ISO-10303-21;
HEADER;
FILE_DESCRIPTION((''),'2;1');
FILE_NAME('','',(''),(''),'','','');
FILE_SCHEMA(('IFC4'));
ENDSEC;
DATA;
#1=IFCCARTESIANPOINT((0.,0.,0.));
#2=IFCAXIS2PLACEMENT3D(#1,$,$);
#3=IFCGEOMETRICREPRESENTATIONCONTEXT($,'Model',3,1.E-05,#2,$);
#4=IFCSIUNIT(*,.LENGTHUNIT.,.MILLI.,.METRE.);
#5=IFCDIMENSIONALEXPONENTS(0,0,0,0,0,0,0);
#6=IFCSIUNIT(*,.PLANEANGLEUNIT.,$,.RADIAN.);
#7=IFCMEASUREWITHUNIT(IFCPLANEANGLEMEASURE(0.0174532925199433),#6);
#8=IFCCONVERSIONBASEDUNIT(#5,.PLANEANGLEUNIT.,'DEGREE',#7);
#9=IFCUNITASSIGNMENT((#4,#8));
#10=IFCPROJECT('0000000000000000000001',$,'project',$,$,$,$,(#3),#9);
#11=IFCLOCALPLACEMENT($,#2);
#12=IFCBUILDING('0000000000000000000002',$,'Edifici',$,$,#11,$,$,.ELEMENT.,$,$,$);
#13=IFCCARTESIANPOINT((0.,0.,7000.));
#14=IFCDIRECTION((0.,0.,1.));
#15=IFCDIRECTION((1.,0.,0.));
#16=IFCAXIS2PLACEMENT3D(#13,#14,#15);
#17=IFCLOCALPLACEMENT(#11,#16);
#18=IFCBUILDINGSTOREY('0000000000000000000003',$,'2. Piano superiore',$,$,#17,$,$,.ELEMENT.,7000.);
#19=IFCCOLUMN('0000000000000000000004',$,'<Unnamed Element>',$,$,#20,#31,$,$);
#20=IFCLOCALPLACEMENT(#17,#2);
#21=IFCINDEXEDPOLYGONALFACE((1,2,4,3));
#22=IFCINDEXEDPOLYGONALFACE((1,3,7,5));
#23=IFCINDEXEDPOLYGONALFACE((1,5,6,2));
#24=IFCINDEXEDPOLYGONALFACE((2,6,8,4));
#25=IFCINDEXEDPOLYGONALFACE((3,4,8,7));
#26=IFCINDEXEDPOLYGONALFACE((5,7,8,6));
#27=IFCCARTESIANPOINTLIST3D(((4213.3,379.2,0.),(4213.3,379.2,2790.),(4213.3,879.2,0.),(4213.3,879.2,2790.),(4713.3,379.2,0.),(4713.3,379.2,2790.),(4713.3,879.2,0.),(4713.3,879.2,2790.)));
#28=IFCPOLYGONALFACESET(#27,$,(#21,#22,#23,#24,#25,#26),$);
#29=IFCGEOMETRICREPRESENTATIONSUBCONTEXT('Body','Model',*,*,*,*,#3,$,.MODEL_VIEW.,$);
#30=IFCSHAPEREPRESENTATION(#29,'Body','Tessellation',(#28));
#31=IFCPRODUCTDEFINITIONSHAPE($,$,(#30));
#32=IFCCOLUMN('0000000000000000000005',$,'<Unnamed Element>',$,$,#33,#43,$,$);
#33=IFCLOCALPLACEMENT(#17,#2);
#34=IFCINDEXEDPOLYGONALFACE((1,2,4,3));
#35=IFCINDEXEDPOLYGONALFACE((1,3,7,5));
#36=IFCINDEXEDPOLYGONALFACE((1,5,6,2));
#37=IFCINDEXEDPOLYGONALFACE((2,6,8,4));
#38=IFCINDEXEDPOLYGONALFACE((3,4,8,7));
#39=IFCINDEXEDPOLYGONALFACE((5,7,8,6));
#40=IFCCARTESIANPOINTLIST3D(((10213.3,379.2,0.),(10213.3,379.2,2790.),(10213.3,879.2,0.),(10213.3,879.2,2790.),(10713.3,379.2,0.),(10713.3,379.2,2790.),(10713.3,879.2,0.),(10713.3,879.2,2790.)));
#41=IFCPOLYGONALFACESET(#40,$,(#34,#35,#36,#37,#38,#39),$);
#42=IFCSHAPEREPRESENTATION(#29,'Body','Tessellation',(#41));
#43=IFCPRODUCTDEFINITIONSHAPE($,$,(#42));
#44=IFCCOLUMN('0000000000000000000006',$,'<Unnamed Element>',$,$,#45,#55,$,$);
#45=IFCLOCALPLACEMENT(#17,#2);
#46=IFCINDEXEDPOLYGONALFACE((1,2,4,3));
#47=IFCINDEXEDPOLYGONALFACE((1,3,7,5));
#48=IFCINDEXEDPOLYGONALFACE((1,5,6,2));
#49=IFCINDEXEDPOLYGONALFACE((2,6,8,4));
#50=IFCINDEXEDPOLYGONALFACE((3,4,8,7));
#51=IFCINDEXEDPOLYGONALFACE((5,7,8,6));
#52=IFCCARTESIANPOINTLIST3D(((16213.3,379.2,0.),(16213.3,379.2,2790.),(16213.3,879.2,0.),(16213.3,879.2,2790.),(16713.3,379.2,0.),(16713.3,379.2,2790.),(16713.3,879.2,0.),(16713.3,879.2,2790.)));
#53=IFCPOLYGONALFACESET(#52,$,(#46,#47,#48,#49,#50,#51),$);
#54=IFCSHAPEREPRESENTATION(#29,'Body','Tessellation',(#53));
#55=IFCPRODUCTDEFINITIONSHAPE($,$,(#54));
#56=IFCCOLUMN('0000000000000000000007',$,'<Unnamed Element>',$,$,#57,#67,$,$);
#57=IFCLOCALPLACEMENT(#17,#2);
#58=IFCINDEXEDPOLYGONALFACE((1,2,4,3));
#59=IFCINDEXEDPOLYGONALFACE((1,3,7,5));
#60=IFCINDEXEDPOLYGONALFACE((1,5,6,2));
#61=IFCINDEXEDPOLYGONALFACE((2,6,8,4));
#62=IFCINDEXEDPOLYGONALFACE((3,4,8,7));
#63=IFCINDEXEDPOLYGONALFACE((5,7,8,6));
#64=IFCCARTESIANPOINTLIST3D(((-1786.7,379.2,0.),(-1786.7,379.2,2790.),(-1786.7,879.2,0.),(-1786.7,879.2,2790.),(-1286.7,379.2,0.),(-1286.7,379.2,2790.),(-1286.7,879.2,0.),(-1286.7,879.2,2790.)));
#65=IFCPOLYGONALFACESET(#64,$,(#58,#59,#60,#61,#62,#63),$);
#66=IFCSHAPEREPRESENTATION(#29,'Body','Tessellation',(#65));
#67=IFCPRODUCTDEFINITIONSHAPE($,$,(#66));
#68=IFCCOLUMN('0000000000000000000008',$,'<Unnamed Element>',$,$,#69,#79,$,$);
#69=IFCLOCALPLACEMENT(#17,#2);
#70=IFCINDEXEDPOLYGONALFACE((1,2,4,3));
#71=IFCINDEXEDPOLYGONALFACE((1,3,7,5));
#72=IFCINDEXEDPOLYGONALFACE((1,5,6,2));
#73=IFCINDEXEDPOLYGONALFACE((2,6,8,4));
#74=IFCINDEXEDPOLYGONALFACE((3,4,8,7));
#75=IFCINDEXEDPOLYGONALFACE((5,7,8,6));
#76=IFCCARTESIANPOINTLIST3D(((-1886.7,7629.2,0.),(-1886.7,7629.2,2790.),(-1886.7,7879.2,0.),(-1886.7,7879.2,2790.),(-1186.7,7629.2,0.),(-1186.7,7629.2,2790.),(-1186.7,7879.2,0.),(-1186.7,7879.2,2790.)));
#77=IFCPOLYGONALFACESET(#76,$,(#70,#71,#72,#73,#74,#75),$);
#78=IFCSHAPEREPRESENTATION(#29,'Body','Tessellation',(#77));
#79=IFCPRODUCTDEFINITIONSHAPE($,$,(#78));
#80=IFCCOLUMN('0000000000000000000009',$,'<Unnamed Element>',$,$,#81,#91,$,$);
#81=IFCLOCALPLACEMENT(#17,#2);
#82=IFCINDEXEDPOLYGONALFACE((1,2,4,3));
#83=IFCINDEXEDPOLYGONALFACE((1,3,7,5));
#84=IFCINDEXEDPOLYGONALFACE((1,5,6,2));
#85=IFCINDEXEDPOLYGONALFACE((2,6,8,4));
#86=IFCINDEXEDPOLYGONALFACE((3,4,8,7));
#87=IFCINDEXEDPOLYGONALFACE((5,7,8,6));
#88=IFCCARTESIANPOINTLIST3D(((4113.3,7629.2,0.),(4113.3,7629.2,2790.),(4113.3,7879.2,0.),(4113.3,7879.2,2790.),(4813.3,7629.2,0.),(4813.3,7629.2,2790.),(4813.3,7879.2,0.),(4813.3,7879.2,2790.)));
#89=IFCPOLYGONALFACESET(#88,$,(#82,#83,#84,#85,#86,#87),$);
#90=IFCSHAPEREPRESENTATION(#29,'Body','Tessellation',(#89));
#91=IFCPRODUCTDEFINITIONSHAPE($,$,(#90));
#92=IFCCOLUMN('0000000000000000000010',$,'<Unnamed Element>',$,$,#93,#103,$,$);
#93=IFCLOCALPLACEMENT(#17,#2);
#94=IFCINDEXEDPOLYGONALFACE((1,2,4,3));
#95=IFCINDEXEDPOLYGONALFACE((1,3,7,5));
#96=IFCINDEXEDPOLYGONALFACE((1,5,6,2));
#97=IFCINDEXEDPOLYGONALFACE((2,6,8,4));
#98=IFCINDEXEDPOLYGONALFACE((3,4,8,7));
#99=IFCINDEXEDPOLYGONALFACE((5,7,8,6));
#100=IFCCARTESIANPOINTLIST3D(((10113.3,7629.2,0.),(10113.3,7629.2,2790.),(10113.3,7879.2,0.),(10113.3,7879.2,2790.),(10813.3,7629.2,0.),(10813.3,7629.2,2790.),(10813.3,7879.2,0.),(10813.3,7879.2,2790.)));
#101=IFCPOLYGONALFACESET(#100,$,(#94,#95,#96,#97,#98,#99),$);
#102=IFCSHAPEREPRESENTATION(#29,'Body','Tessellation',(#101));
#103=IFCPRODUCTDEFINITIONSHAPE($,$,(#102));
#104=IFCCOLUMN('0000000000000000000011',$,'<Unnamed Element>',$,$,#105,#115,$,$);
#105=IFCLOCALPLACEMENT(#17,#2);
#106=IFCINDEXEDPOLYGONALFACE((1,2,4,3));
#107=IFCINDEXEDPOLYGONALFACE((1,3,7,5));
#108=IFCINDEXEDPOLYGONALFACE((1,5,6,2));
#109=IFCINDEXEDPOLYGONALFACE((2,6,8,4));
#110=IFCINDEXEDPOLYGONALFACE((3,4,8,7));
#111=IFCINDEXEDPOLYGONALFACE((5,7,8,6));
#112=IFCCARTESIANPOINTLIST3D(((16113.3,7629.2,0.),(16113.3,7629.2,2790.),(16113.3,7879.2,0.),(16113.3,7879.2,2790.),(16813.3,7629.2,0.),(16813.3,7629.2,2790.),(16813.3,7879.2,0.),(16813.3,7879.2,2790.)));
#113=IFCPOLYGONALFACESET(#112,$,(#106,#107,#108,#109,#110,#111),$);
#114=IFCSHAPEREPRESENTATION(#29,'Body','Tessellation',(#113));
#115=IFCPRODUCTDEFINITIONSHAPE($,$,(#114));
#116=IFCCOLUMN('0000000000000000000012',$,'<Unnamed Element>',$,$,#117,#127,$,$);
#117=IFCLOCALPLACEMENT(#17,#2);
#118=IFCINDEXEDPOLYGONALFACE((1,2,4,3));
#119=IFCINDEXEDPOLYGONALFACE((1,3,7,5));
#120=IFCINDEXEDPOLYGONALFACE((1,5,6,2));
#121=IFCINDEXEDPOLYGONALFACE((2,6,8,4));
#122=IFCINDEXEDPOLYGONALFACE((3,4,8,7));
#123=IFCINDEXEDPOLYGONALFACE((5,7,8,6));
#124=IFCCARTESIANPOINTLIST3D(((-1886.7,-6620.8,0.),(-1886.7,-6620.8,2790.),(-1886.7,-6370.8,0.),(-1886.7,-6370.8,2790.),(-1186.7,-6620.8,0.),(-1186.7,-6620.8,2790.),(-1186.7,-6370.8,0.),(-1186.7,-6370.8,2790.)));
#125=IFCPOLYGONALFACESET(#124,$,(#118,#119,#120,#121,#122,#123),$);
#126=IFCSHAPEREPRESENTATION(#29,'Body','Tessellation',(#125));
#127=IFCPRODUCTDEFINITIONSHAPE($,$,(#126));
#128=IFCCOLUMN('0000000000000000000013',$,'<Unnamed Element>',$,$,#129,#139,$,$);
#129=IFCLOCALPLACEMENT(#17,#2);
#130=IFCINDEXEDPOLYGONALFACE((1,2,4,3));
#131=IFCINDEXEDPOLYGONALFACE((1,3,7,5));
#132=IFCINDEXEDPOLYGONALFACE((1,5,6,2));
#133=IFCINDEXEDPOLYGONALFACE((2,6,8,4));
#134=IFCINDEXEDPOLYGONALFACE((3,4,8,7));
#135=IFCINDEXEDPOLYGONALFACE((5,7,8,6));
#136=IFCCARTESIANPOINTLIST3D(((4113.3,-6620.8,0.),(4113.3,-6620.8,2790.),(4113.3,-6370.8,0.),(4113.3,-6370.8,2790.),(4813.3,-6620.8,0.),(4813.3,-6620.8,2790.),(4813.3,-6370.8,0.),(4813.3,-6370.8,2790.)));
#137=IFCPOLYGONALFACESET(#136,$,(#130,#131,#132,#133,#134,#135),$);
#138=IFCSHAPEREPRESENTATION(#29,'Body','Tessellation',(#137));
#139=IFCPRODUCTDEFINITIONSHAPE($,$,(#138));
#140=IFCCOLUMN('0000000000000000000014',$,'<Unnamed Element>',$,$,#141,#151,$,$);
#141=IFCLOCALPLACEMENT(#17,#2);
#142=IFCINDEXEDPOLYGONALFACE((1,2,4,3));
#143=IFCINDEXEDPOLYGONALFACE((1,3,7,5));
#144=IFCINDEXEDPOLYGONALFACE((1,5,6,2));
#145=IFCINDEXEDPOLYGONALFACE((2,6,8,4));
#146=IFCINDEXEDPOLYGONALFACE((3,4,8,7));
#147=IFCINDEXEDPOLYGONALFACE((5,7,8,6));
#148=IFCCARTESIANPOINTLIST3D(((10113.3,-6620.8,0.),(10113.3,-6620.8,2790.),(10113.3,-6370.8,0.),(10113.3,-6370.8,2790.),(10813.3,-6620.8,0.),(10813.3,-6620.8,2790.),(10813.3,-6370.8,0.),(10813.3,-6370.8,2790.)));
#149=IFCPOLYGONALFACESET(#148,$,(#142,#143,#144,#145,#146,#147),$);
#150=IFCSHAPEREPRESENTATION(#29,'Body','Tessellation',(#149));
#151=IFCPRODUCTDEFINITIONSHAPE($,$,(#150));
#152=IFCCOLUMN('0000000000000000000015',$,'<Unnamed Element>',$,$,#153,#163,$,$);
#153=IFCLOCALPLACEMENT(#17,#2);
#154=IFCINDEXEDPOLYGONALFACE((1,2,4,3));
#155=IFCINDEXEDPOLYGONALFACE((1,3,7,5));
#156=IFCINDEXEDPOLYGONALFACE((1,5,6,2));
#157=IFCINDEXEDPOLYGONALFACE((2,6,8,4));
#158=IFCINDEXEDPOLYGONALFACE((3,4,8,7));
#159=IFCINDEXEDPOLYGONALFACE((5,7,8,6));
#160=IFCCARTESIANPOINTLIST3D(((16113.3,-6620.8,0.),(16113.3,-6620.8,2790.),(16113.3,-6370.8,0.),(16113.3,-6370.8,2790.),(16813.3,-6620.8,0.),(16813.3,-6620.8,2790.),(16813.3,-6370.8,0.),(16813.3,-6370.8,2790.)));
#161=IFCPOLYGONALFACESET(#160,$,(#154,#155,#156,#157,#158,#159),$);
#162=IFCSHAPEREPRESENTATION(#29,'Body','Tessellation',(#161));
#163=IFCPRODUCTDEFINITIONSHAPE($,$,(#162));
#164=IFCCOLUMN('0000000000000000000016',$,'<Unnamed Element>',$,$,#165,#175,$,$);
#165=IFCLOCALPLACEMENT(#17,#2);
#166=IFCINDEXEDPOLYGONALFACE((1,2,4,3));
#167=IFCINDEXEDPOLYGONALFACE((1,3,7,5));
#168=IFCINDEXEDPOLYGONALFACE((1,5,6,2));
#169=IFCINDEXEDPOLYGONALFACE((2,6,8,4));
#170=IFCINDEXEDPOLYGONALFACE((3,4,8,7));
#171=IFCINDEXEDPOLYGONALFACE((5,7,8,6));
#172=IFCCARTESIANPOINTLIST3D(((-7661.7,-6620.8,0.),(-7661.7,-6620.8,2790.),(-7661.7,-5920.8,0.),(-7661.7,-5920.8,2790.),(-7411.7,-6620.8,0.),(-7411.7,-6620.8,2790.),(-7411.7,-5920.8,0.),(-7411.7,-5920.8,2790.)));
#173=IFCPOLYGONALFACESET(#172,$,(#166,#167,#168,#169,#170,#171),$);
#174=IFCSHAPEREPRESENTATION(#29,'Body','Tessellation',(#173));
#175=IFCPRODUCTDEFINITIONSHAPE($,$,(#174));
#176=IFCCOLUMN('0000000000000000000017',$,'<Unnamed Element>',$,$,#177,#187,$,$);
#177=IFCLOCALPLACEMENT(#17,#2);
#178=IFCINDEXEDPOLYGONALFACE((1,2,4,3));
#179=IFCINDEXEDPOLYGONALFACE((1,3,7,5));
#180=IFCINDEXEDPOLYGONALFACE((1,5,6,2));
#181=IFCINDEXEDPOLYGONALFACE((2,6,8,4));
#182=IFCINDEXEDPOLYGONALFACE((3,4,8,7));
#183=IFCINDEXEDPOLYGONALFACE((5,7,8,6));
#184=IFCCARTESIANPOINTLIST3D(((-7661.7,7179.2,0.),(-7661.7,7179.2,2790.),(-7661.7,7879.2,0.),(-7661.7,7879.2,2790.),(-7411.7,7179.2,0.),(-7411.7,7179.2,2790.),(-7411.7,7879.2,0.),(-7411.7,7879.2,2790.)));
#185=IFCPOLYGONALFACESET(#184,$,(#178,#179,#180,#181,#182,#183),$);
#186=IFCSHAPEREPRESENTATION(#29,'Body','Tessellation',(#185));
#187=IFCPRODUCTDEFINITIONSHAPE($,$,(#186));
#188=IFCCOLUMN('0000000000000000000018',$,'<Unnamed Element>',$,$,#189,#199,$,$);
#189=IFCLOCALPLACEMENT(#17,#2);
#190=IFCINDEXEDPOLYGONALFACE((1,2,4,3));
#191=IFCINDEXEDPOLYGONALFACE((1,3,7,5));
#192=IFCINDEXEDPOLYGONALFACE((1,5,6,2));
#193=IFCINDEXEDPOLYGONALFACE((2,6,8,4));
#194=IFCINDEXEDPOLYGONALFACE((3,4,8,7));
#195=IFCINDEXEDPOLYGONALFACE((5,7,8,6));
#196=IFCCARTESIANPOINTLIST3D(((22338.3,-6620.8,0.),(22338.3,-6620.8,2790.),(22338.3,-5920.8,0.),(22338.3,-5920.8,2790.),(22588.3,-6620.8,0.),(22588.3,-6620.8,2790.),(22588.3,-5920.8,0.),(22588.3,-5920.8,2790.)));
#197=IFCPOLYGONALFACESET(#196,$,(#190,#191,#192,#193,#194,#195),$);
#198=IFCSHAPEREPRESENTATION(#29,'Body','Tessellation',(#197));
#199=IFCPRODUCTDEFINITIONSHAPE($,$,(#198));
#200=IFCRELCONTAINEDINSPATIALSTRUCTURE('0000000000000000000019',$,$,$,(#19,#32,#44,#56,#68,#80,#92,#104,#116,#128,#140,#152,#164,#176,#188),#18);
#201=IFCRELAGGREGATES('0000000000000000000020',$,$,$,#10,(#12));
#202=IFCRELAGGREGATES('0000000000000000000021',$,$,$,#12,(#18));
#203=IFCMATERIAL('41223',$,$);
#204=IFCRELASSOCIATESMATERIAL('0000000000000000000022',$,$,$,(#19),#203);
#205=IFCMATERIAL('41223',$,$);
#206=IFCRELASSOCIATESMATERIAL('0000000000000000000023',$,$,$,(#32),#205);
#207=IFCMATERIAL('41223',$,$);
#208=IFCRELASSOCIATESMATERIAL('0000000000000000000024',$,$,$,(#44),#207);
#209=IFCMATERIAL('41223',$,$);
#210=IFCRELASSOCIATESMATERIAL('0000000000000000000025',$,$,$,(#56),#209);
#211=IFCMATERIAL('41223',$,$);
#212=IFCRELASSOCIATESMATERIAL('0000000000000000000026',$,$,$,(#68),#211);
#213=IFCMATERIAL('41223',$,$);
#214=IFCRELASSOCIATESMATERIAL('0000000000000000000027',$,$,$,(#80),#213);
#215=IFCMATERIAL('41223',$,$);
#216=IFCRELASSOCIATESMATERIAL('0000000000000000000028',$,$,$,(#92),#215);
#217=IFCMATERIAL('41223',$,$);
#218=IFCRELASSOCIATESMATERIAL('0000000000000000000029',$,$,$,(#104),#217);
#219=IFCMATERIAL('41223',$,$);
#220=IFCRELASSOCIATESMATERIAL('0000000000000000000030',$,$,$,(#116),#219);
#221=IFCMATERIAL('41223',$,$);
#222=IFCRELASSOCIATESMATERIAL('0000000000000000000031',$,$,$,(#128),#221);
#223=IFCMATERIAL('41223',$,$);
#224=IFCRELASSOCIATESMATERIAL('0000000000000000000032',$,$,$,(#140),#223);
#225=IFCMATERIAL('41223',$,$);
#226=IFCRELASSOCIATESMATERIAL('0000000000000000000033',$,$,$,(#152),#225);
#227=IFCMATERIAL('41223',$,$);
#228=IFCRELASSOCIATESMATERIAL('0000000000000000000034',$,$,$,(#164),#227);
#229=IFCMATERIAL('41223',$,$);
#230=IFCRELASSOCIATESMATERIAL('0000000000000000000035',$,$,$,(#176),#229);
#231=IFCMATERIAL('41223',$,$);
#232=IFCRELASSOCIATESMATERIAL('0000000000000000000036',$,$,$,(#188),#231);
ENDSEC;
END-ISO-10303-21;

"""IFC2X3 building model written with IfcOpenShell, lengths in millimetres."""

from ifc_helpers import new_model, entity, si_unit, converted_unit, frame, frame_2d, origin, origin_with_axes, place, context, subcontext, project, spatial, rectangle, extrude, material, element, save


model = new_model("IFC2X3")

# Units and contexts
model_context = context("Model", 3, precision=1e-05, world=origin())
body_context = subcontext(model_context, "Body", "Model", "MODEL_VIEW")
ifc_project = project(units=[si_unit("LENGTHUNIT", "METRE", prefix="MILLI"), converted_unit("PLANEANGLEUNIT", "DEGREE", entity("IfcPlaneAngleMeasure", 0.0174532925199433), si_unit("PLANEANGLEUNIT", "RADIAN"), dimensions=[0, 0, 0, 0, 0, 0, 0])], contexts=[model_context])

# Building, storey
building_placement = place(None, origin())
building = spatial("IfcBuilding", under=ifc_project, at=building_placement, Name="Edifici", CompositionType="ELEMENT")
storey_placement = place(building_placement, frame((0.0, 0.0, 7000.0), z_axis=(0.0, 0.0, 1.0), x_axis=(1.0, 0.0, 0.0)))
storey = spatial("IfcBuildingStorey", under=building, at=storey_placement, Name="2. Piano superiore", CompositionType="ELEMENT", Elevation=7000.0)

# Columns
ifc_material_1 = material(Name="41223")
column_1_placement = place(storey_placement, frame((4213.3, 379.2, 0.0), z_axis=(0.0, 0.0, 1.0), x_axis=(1.0, 0.0, 0.0)))
element("IfcColumn", 1, at=column_1_placement, inside=storey, material=ifc_material_1, Name="<Unnamed Element>", context=body_context, shape_type="SweptSolid", body=[
    extrude(rectangle(XDim=500.0, YDim=500.0, at=frame_2d((250.0, 250.0), x_axis=(1.0, 0.0))), origin_with_axes(), (0.0, 0.0, 1.0), 2790.0),
])
ifc_material_2 = material(Name="41223")
column_2_placement = place(storey_placement, frame((10213.3, 379.2, 0.0), z_axis=(0.0, 0.0, 1.0), x_axis=(1.0, 0.0, 0.0)))
element("IfcColumn", 2, at=column_2_placement, inside=storey, material=ifc_material_2, Name="<Unnamed Element>", context=body_context, shape_type="SweptSolid", body=[
    extrude(rectangle(XDim=500.0, YDim=500.0, at=frame_2d((250.0, 250.0), x_axis=(1.0, 0.0))), origin_with_axes(), (0.0, 0.0, 1.0), 2790.0),
])
ifc_material_3 = material(Name="41223")
column_3_placement = place(storey_placement, frame((16213.3, 379.2, 0.0), z_axis=(0.0, 0.0, 1.0), x_axis=(1.0, 0.0, 0.0)))
element("IfcColumn", 3, at=column_3_placement, inside=storey, material=ifc_material_3, Name="<Unnamed Element>", context=body_context, shape_type="SweptSolid", body=[
    extrude(rectangle(XDim=500.0, YDim=500.0, at=frame_2d((250.0, 250.0), x_axis=(1.0, 0.0))), origin_with_axes(), (0.0, 0.0, 1.0), 2790.0),
])
ifc_material_4 = material(Name="41223")
column_4_placement = place(storey_placement, frame((-1786.7, 379.2, 0.0), z_axis=(0.0, 0.0, 1.0), x_axis=(1.0, 0.0, 0.0)))
element("IfcColumn", 4, at=column_4_placement, inside=storey, material=ifc_material_4, Name="<Unnamed Element>", context=body_context, shape_type="SweptSolid", body=[
    extrude(rectangle(XDim=500.0, YDim=500.0, at=frame_2d((250.0, 250.0), x_axis=(1.0, 0.0))), origin_with_axes(), (0.0, 0.0, 1.0), 2790.0),
])
ifc_material_5 = material(Name="41223")
column_5_placement = place(storey_placement, frame((-1186.7, 7629.2, 0.0), z_axis=(0.0, 0.0, 1.0), x_axis=(1.0, 0.0, 0.0)))
element("IfcColumn", 5, at=column_5_placement, inside=storey, material=ifc_material_5, Name="<Unnamed Element>", context=body_context, shape_type="SweptSolid", body=[
    extrude(rectangle(XDim=250.0, YDim=700.0, at=frame_2d((-350.0, 125.0), x_axis=(0.0, 1.0))), origin_with_axes(), (0.0, 0.0, 1.0), 2790.0),
])
ifc_material_6 = material(Name="41223")
column_6_placement = place(storey_placement, frame((4813.3, 7629.2, 0.0), z_axis=(0.0, 0.0, 1.0), x_axis=(1.0, 0.0, 0.0)))
element("IfcColumn", 6, at=column_6_placement, inside=storey, material=ifc_material_6, Name="<Unnamed Element>", context=body_context, shape_type="SweptSolid", body=[
    extrude(rectangle(XDim=250.0, YDim=700.0, at=frame_2d((-350.0, 125.0), x_axis=(0.0, 1.0))), origin_with_axes(), (0.0, 0.0, 1.0), 2790.0),
])
ifc_material_7 = material(Name="41223")
column_7_placement = place(storey_placement, frame((10813.3, 7629.2, 0.0), z_axis=(0.0, 0.0, 1.0), x_axis=(1.0, 0.0, 0.0)))
element("IfcColumn", 7, at=column_7_placement, inside=storey, material=ifc_material_7, Name="<Unnamed Element>", context=body_context, shape_type="SweptSolid", body=[
    extrude(rectangle(XDim=250.0, YDim=700.0, at=frame_2d((-350.0, 125.0), x_axis=(0.0, 1.0))), origin_with_axes(), (0.0, 0.0, 1.0), 2790.0),
])
ifc_material_8 = material(Name="41223")
column_8_placement = place(storey_placement, frame((16813.3, 7629.2, 0.0), z_axis=(0.0, 0.0, 1.0), x_axis=(1.0, 0.0, 0.0)))
element("IfcColumn", 8, at=column_8_placement, inside=storey, material=ifc_material_8, Name="<Unnamed Element>", context=body_context, shape_type="SweptSolid", body=[
    extrude(rectangle(XDim=250.0, YDim=700.0, at=frame_2d((-350.0, 125.0), x_axis=(0.0, 1.0))), origin_with_axes(), (0.0, 0.0, 1.0), 2790.0),
])
ifc_material_9 = material(Name="41223")
column_9_placement = place(storey_placement, frame((-1186.7, -6620.8, 0.0), z_axis=(0.0, 0.0, 1.0), x_axis=(1.0, 0.0, 0.0)))
element("IfcColumn", 9, at=column_9_placement, inside=storey, material=ifc_material_9, Name="<Unnamed Element>", context=body_context, shape_type="SweptSolid", body=[
    extrude(rectangle(XDim=250.0, YDim=700.0, at=frame_2d((-350.0, 125.0), x_axis=(0.0, 1.0))), origin_with_axes(), (0.0, 0.0, 1.0), 2790.0),
])
ifc_material_10 = material(Name="41223")
column_10_placement = place(storey_placement, frame((4813.3, -6620.8, 0.0), z_axis=(0.0, 0.0, 1.0), x_axis=(1.0, 0.0, 0.0)))
element("IfcColumn", 10, at=column_10_placement, inside=storey, material=ifc_material_10, Name="<Unnamed Element>", context=body_context, shape_type="SweptSolid", body=[
    extrude(rectangle(XDim=250.0, YDim=700.0, at=frame_2d((-350.0, 125.0), x_axis=(0.0, 1.0))), origin_with_axes(), (0.0, 0.0, 1.0), 2790.0),
])
ifc_material_11 = material(Name="41223")
column_11_placement = place(storey_placement, frame((10813.3, -6620.8, 0.0), z_axis=(0.0, 0.0, 1.0), x_axis=(1.0, 0.0, 0.0)))
element("IfcColumn", 11, at=column_11_placement, inside=storey, material=ifc_material_11, Name="<Unnamed Element>", context=body_context, shape_type="SweptSolid", body=[
    extrude(rectangle(XDim=250.0, YDim=700.0, at=frame_2d((-350.0, 125.0), x_axis=(0.0, 1.0))), origin_with_axes(), (0.0, 0.0, 1.0), 2790.0),
])
ifc_material_12 = material(Name="41223")
column_12_placement = place(storey_placement, frame((16813.3, -6620.8, 0.0), z_axis=(0.0, 0.0, 1.0), x_axis=(1.0, 0.0, 0.0)))
element("IfcColumn", 12, at=column_12_placement, inside=storey, material=ifc_material_12, Name="<Unnamed Element>", context=body_context, shape_type="SweptSolid", body=[
    extrude(rectangle(XDim=250.0, YDim=700.0, at=frame_2d((-350.0, 125.0), x_axis=(0.0, 1.0))), origin_with_axes(), (0.0, 0.0, 1.0), 2790.0),
])
ifc_material_13 = material(Name="41223")
column_13_placement = place(storey_placement, frame((-7411.7, -5920.8, 0.0), z_axis=(0.0, 0.0, 1.0), x_axis=(1.0, 0.0, 0.0)))
element("IfcColumn", 13, at=column_13_placement, inside=storey, material=ifc_material_13, Name="<Unnamed Element>", context=body_context, shape_type="SweptSolid", body=[
    extrude(rectangle(XDim=250.0, YDim=700.0, at=frame_2d((-125.0, -350.0), x_axis=(-1.0, 0.0))), origin_with_axes(), (0.0, 0.0, 1.0), 2790.0),
])
ifc_material_14 = material(Name="41223")
column_14_placement = place(storey_placement, frame((-7411.7, 7879.2, 0.0), z_axis=(0.0, 0.0, 1.0), x_axis=(1.0, 0.0, 0.0)))
element("IfcColumn", 14, at=column_14_placement, inside=storey, material=ifc_material_14, Name="<Unnamed Element>", context=body_context, shape_type="SweptSolid", body=[
    extrude(rectangle(XDim=250.0, YDim=700.0, at=frame_2d((-125.0, -350.0), x_axis=(-1.0, 0.0))), origin_with_axes(), (0.0, 0.0, 1.0), 2790.0),
])
ifc_material_15 = material(Name="41223")
column_15_placement = place(storey_placement, frame((22588.3, -5920.8, 0.0), z_axis=(0.0, 0.0, 1.0), x_axis=(1.0, 0.0, 0.0)))
element("IfcColumn", 15, at=column_15_placement, inside=storey, material=ifc_material_15, Name="<Unnamed Element>", context=body_context, shape_type="SweptSolid", body=[
    extrude(rectangle(XDim=250.0, YDim=700.0, at=frame_2d((-125.0, -350.0), x_axis=(-1.0, 0.0))), origin_with_axes(), (0.0, 0.0, 1.0), 2790.0),
])

save(model, "model.ifc")
